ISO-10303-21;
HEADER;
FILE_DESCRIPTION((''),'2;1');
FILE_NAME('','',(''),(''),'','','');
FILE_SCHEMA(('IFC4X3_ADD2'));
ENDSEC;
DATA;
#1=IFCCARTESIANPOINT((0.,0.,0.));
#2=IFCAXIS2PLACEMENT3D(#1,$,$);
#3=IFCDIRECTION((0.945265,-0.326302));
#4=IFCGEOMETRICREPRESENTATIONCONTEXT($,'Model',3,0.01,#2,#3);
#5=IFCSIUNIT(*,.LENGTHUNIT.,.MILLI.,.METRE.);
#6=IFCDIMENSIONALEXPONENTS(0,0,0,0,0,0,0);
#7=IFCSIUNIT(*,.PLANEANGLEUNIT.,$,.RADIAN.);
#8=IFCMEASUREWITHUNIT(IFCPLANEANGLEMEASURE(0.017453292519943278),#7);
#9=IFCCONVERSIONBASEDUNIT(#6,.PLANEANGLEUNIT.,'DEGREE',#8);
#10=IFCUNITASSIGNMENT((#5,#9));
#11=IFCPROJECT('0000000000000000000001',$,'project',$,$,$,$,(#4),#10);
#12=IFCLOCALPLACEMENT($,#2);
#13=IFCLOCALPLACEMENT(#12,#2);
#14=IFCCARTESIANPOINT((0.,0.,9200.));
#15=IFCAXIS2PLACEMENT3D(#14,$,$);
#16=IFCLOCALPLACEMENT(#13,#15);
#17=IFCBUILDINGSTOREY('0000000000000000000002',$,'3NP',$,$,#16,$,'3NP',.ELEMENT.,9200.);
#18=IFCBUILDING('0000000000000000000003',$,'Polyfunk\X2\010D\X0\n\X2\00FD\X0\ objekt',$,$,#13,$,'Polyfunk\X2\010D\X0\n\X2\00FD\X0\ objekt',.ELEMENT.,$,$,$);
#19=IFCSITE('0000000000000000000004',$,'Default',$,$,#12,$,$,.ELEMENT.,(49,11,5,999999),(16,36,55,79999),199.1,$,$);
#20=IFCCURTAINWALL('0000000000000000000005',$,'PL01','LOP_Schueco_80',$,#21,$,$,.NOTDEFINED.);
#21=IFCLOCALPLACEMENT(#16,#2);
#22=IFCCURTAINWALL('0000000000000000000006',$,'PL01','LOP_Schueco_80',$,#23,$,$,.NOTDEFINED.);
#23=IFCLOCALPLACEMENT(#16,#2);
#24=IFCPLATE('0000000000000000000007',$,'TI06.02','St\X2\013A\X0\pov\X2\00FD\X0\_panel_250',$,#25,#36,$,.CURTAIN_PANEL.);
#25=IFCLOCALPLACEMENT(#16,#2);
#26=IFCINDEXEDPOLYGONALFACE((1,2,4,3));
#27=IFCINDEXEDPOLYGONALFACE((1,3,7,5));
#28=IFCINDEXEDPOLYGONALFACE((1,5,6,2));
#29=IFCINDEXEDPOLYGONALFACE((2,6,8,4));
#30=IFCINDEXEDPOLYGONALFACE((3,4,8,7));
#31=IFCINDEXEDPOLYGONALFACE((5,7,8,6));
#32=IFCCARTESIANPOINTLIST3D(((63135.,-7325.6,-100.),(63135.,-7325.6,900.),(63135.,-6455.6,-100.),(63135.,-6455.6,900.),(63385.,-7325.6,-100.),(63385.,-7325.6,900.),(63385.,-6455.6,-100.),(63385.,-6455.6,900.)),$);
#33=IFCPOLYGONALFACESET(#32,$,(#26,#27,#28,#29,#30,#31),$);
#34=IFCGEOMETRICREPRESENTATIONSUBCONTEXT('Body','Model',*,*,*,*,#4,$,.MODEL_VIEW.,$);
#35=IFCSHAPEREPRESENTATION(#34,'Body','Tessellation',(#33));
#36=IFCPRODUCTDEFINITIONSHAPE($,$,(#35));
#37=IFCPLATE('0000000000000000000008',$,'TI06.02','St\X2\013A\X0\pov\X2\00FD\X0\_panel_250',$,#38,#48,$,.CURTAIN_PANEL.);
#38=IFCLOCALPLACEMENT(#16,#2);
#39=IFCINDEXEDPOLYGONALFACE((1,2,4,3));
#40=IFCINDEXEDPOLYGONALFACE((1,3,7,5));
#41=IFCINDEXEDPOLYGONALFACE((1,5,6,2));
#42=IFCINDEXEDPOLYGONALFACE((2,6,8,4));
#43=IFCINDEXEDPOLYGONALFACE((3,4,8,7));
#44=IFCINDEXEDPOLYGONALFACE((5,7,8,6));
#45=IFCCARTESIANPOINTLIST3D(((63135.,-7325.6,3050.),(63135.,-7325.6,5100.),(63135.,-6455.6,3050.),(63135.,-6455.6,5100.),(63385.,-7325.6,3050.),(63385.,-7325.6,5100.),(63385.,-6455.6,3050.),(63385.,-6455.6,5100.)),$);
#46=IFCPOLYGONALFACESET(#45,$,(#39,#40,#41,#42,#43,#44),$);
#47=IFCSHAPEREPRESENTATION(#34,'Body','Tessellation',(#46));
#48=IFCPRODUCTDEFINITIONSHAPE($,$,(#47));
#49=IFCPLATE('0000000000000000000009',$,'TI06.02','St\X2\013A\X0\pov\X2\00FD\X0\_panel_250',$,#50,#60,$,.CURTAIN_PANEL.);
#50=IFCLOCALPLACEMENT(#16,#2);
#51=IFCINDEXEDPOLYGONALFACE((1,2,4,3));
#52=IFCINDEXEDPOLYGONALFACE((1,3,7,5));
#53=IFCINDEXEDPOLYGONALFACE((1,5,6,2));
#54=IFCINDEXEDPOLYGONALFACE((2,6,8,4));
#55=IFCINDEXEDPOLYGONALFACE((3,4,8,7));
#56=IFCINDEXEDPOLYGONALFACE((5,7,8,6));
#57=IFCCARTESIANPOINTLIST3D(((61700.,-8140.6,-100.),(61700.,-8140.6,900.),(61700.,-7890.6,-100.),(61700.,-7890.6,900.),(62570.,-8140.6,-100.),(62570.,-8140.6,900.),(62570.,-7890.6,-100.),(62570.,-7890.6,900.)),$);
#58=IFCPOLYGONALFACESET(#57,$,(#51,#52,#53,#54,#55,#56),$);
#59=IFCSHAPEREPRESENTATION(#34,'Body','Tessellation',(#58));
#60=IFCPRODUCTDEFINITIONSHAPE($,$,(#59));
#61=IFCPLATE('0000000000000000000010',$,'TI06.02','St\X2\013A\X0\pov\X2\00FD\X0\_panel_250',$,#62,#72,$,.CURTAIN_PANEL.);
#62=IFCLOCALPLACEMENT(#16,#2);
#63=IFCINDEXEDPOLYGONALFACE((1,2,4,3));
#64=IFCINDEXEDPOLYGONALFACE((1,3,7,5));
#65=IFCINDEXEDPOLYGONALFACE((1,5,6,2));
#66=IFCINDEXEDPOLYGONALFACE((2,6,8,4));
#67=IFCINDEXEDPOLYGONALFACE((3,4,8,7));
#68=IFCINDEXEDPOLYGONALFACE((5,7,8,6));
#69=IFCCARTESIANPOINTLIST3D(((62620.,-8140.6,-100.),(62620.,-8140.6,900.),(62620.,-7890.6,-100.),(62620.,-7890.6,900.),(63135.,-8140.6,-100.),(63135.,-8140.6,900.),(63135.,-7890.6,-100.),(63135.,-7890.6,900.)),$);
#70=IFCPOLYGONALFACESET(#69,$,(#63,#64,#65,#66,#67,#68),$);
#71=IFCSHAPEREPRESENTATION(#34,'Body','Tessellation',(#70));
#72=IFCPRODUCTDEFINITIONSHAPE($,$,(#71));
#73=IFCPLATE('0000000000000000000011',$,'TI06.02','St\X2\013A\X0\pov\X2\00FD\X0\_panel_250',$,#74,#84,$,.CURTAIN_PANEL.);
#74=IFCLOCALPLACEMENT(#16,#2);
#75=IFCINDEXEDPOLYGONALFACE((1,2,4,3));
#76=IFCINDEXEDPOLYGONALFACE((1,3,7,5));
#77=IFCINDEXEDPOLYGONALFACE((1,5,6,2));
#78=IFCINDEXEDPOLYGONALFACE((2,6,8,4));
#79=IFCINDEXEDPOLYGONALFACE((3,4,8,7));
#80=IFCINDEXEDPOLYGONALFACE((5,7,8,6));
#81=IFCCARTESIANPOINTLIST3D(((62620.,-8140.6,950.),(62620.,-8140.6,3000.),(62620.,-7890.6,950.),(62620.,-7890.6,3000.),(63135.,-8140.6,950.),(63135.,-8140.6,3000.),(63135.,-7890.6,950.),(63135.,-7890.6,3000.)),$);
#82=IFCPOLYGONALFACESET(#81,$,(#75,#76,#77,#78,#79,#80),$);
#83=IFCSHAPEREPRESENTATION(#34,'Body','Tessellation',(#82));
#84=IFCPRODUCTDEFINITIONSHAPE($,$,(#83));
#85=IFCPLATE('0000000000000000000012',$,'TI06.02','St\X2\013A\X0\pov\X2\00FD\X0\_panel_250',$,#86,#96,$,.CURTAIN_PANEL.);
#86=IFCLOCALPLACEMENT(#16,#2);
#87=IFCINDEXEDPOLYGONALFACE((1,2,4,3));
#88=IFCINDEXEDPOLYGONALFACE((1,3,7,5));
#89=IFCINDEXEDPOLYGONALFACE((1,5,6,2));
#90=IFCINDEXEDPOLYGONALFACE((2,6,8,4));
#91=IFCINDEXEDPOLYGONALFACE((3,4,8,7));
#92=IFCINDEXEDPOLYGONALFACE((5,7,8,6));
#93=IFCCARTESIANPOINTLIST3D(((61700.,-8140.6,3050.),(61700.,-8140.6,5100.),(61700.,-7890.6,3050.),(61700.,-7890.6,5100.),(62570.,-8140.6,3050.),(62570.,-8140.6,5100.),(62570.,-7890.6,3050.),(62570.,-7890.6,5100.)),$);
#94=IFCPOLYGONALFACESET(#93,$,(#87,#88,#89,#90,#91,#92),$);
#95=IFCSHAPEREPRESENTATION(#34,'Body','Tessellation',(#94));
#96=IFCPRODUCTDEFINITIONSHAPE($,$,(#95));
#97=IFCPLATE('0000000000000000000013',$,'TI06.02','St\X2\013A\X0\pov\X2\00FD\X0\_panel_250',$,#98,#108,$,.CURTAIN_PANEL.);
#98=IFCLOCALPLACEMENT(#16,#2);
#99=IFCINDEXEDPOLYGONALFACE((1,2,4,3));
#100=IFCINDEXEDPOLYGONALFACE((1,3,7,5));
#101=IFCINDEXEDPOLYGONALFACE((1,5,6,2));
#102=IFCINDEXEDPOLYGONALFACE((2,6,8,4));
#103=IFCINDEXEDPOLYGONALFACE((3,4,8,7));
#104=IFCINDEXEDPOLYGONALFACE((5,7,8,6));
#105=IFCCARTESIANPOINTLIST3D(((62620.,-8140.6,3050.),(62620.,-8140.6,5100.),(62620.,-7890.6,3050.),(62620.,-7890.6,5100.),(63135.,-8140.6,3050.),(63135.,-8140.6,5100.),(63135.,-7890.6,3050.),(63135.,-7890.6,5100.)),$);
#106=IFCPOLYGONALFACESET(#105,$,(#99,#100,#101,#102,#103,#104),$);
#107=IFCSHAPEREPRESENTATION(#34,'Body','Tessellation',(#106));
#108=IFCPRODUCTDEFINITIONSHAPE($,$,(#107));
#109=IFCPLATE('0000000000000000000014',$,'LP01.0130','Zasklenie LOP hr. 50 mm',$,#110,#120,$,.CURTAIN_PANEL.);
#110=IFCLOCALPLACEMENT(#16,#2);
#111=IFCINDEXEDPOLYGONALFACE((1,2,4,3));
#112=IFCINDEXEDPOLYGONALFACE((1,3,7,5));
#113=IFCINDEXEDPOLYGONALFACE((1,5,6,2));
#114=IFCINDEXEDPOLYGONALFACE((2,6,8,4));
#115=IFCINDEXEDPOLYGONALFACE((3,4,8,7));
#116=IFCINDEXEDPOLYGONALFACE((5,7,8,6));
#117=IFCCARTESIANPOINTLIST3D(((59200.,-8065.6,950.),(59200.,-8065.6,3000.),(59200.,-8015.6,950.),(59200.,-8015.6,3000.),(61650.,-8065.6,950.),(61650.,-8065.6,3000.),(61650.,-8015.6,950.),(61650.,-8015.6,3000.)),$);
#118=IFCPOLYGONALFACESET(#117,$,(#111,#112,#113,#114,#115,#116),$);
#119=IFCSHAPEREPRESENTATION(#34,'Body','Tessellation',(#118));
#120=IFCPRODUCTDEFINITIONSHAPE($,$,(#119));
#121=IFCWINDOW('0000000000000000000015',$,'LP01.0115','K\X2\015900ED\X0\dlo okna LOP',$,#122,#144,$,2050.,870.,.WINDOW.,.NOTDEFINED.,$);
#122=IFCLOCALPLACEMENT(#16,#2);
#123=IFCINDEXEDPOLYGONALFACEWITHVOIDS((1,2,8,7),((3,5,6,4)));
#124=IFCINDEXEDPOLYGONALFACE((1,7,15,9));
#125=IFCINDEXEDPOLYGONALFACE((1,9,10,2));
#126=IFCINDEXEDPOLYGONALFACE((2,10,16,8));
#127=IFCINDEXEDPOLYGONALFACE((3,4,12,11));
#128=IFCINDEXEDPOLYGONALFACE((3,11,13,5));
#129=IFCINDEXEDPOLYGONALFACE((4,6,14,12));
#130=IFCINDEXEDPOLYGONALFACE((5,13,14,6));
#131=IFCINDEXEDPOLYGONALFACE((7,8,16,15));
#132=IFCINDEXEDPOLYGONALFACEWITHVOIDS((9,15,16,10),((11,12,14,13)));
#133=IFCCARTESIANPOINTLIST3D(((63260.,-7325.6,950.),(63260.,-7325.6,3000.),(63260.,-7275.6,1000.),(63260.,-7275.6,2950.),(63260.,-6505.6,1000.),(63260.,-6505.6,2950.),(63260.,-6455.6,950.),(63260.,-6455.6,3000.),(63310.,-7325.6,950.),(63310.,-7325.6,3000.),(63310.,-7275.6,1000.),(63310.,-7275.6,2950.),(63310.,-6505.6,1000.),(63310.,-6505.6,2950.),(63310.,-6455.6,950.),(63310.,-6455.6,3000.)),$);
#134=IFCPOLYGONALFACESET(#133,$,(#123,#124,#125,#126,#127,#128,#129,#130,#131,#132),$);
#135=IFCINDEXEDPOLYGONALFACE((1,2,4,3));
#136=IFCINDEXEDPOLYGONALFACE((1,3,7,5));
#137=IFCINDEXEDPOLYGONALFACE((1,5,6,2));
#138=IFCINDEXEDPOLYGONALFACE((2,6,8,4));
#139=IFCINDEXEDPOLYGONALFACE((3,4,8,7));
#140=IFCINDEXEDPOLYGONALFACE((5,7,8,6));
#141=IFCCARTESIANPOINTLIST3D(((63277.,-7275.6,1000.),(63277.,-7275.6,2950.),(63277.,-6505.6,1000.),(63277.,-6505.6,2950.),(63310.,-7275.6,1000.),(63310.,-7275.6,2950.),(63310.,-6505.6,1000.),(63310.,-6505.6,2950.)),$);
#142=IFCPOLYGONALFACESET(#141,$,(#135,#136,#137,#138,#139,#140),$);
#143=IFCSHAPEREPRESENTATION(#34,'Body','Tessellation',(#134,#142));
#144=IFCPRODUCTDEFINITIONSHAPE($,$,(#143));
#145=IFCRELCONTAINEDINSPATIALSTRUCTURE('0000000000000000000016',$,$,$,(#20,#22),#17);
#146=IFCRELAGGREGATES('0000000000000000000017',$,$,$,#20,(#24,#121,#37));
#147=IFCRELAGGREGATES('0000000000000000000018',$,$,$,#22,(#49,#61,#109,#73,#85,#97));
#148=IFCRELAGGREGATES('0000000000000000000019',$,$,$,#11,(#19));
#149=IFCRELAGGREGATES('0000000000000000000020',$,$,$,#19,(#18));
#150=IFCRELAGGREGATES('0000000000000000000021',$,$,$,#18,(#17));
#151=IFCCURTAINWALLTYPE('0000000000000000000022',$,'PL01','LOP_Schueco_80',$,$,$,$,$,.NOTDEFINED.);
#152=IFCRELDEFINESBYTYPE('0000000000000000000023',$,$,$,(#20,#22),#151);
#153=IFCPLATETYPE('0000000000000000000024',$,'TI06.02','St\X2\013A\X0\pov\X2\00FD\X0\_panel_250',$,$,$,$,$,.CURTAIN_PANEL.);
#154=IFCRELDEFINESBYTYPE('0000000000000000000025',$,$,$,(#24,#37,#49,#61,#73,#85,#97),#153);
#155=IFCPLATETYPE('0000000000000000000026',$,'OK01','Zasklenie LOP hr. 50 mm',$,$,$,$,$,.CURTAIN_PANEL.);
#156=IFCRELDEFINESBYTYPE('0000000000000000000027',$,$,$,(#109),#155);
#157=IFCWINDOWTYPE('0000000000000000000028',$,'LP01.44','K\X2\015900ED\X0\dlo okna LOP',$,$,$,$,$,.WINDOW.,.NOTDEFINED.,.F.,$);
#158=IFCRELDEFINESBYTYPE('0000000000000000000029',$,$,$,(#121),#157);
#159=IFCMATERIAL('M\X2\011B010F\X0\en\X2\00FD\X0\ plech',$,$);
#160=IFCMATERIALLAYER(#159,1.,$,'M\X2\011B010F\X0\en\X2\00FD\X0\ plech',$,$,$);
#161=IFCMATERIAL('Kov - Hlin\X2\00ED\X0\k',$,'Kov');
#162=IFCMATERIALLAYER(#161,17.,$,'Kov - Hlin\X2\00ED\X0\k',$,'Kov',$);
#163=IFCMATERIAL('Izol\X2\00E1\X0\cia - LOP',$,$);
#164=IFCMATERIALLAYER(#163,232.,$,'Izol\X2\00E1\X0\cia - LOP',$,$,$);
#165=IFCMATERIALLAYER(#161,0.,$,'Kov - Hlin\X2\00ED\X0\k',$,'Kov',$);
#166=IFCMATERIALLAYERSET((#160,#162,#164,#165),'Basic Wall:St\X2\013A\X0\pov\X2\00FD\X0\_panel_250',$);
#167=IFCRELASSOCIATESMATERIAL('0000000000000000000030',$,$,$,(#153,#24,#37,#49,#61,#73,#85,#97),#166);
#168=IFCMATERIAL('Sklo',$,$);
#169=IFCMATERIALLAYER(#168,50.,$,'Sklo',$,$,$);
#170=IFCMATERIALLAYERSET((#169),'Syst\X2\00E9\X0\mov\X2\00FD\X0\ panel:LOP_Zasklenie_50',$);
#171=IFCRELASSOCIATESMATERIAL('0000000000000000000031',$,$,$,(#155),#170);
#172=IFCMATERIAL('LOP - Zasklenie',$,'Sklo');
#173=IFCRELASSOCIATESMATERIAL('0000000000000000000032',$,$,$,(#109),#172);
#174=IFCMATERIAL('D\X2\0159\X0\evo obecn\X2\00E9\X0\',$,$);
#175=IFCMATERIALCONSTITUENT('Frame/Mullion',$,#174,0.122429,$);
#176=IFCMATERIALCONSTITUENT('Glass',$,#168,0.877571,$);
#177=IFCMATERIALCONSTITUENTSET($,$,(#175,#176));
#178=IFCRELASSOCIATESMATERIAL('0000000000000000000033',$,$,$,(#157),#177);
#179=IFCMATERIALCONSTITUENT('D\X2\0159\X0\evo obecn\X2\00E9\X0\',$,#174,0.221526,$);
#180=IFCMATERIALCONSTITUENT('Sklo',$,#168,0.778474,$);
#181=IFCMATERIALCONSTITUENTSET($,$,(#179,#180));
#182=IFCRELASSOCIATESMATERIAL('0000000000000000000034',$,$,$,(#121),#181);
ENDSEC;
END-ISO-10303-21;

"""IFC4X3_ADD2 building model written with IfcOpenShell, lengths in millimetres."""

from ifc_helpers import new_model, entity, si_unit, converted_unit, direction, frame, frame_2d, origin, origin_2d_with_axis, place, context, subcontext, project, spatial, polyline, rectangle, outline, extrude, source, transform, mapped, material, layer, layer_set, layer_usage, constituent, constituent_set, type_object, type_shapes, element, aggregate, save


model = new_model("IFC4X3_ADD2")

# Units and contexts
model_context = context("Model", 3, precision=0.01, world=origin(), true_north=direction((0.945265, -0.326302)))
body_context = subcontext(model_context, "Body", "Model", "MODEL_VIEW")
ifc_project = project(units=[si_unit("LENGTHUNIT", "METRE", prefix="MILLI"), converted_unit("PLANEANGLEUNIT", "DEGREE", entity("IfcPlaneAngleMeasure", 0.017453292519943278), si_unit("PLANEANGLEUNIT", "RADIAN"), dimensions=[0, 0, 0, 0, 0, 0, 0])], contexts=[model_context])

# Site, building, storey
site_placement = place(None, origin())
site = spatial("IfcSite", under=ifc_project, at=site_placement, Name="Default", CompositionType="ELEMENT", RefLatitude=(49, 11, 5, 999999), RefLongitude=(16, 36, 55, 79999), RefElevation=199.1)
building_placement = place(site_placement, origin())
building = spatial("IfcBuilding", under=site, at=building_placement, Name="Polyfunkčný objekt", LongName="Polyfunkčný objekt", CompositionType="ELEMENT")
storey_placement = place(building_placement, frame((0.0, 0.0, 9200.0)))
storey = spatial("IfcBuildingStorey", under=building, at=storey_placement, Name="3NP", LongName="3NP", CompositionType="ELEMENT", Elevation=9200.0)

# Curtain walls
curtain_wall_type = type_object("IfcCurtainWallType", Name="PL01", Description="LOP_Schueco_80", PredefinedType="NOTDEFINED")
curtain_wall_1_placement = place(storey_placement, frame((0.0, 0.0, -9200.0)))
curtain_wall_1 = element("IfcCurtainWall", 1, at=curtain_wall_1_placement, inside=storey, type_object=curtain_wall_type, Name="PL01", Description="LOP_Schueco_80", PredefinedType="NOTDEFINED")
curtain_wall_2_placement = place(storey_placement, frame((0.0, 0.0, -9200.0)))
curtain_wall_2 = element("IfcCurtainWall", 2, at=curtain_wall_2_placement, inside=storey, type_object=curtain_wall_type, Name="PL01", Description="LOP_Schueco_80", PredefinedType="NOTDEFINED")

# Plates
ifc_material_1 = material(Name="Měďený plech")
ifc_layer_1 = layer(ifc_material_1, 1.0, Name="Měďený plech")
ifc_material_2 = material(Name="Kov - Hliník", Category="Kov")
ifc_layer_2 = layer(ifc_material_2, 17.0, Name="Kov - Hliník", Category="Kov")
ifc_material_3 = material(Name="Izolácia - LOP")
ifc_layer_3 = layer(ifc_material_3, 232.0, Name="Izolácia - LOP")
ifc_layer_4 = layer(ifc_material_2, 0.0, Name="Kov - Hliník", Category="Kov")
ifc_layer_set_1 = layer_set([ifc_layer_1, ifc_layer_2, ifc_layer_3, ifc_layer_4], Name="Basic Wall:Stĺpový_panel_250")
ifc_layer_usage_1 = layer_usage(ifc_layer_set_1, "AXIS2", "NEGATIVE", 125.0)
plate_type_1 = type_object("IfcPlateType", Name="TI06.02", Description="Stĺpový_panel_250", PredefinedType="CURTAIN_PANEL", material=ifc_layer_set_1)
plate_1_placement = place(storey_placement, frame((63260.0, -6455.6, -100.0), z_axis=(0.0, 0.0, 1.0), x_axis=(0.0, -1.0, 0.0)))
plate_1 = element("IfcPlate", 3, at=plate_1_placement, type_object=plate_type_1, material=ifc_layer_usage_1, Name="TI06.02", Description="Stĺpový_panel_250", PredefinedType="CURTAIN_PANEL", context=body_context, shape_type="SweptSolid", body=[
    extrude(rectangle(XDim=250.0, YDim=870.0, at=frame_2d((0.0, 0.0), x_axis=(1.0, 0.0))), frame((435.0, 0.0, 0.0), z_axis=(0.0, 0.0, 1.0), x_axis=(0.0, 1.0, 0.0)), (0.0, 0.0, 1.0), 1000.0),
])
ifc_layer_usage_2 = layer_usage(ifc_layer_set_1, "AXIS2", "NEGATIVE", 125.0)
plate_2_placement = place(storey_placement, frame((63260.0, -6455.6, 3050.0), z_axis=(0.0, 0.0, 1.0), x_axis=(0.0, -1.0, 0.0)))
plate_2 = element("IfcPlate", 4, at=plate_2_placement, type_object=plate_type_1, material=ifc_layer_usage_2, Name="TI06.02", Description="Stĺpový_panel_250", PredefinedType="CURTAIN_PANEL", context=body_context, shape_type="SweptSolid", body=[
    extrude(rectangle(XDim=250.0, YDim=870.0, at=frame_2d((0.0, 0.0), x_axis=(1.0, 0.0))), frame((435.0, 0.0, 0.0), z_axis=(0.0, 0.0, 1.0), x_axis=(0.0, 1.0, 0.0)), (0.0, 0.0, 1.0), 2050.0),
])
ifc_layer_usage_3 = layer_usage(ifc_layer_set_1, "AXIS2", "POSITIVE", -125.0)
plate_3_placement = place(storey_placement, frame((61700.0, -8015.6, -100.0)))
plate_3 = element("IfcPlate", 5, at=plate_3_placement, type_object=plate_type_1, material=ifc_layer_usage_3, Name="TI06.02", Description="Stĺpový_panel_250", PredefinedType="CURTAIN_PANEL", context=body_context, shape_type="SweptSolid", body=[
    extrude(rectangle(XDim=250.0, YDim=870.0, at=frame_2d((0.0, 0.0), x_axis=(1.0, 0.0))), frame((435.0, 0.0, 0.0), z_axis=(0.0, 0.0, 1.0), x_axis=(0.0, 1.0, 0.0)), (0.0, 0.0, 1.0), 1000.0),
])
ifc_layer_usage_4 = layer_usage(ifc_layer_set_1, "AXIS2", "POSITIVE", -125.0)
plate_4_placement = place(storey_placement, frame((62620.0, -8015.6, -100.0)))
plate_4 = element("IfcPlate", 6, at=plate_4_placement, type_object=plate_type_1, material=ifc_layer_usage_4, Name="TI06.02", Description="Stĺpový_panel_250", PredefinedType="CURTAIN_PANEL", context=body_context, shape_type="SweptSolid", body=[
    extrude(rectangle(XDim=250.0, YDim=515.0, at=frame_2d((0.0, 0.0), x_axis=(1.0, 0.0))), frame((257.5, 0.0, 0.0), z_axis=(0.0, 0.0, 1.0), x_axis=(0.0, 1.0, 0.0)), (0.0, 0.0, 1.0), 1000.0),
])
ifc_layer_usage_5 = layer_usage(ifc_layer_set_1, "AXIS2", "POSITIVE", -125.0)
plate_5_placement = place(storey_placement, frame((62620.0, -8015.6, 950.0)))
plate_5 = element("IfcPlate", 7, at=plate_5_placement, type_object=plate_type_1, material=ifc_layer_usage_5, Name="TI06.02", Description="Stĺpový_panel_250", PredefinedType="CURTAIN_PANEL", context=body_context, shape_type="SweptSolid", body=[
    extrude(rectangle(XDim=250.0, YDim=515.0, at=frame_2d((0.0, 0.0), x_axis=(1.0, 0.0))), frame((257.5, 0.0, 0.0), z_axis=(0.0, 0.0, 1.0), x_axis=(0.0, 1.0, 0.0)), (0.0, 0.0, 1.0), 2050.0),
])
ifc_layer_usage_6 = layer_usage(ifc_layer_set_1, "AXIS2", "POSITIVE", -125.0)
plate_6_placement = place(storey_placement, frame((61700.0, -8015.6, 3050.0)))
plate_6 = element("IfcPlate", 8, at=plate_6_placement, type_object=plate_type_1, material=ifc_layer_usage_6, Name="TI06.02", Description="Stĺpový_panel_250", PredefinedType="CURTAIN_PANEL", context=body_context, shape_type="SweptSolid", body=[
    extrude(rectangle(XDim=250.0, YDim=870.0, at=frame_2d((0.0, 0.0), x_axis=(1.0, 0.0))), frame((435.0, 0.0, 0.0), z_axis=(0.0, 0.0, 1.0), x_axis=(0.0, 1.0, 0.0)), (0.0, 0.0, 1.0), 2050.0),
])
ifc_layer_usage_7 = layer_usage(ifc_layer_set_1, "AXIS2", "POSITIVE", -125.0)
plate_7_placement = place(storey_placement, frame((62620.0, -8015.6, 3050.0)))
plate_7 = element("IfcPlate", 9, at=plate_7_placement, type_object=plate_type_1, material=ifc_layer_usage_7, Name="TI06.02", Description="Stĺpový_panel_250", PredefinedType="CURTAIN_PANEL", context=body_context, shape_type="SweptSolid", body=[
    extrude(rectangle(XDim=250.0, YDim=515.0, at=frame_2d((0.0, 0.0), x_axis=(1.0, 0.0))), frame((257.5, 0.0, 0.0), z_axis=(0.0, 0.0, 1.0), x_axis=(0.0, 1.0, 0.0)), (0.0, 0.0, 1.0), 2050.0),
])
ifc_material_4 = material(Name="LOP - Zasklenie", Category="Sklo")
ifc_material_5 = material(Name="Sklo")
ifc_layer_5 = layer(ifc_material_5, 50.0, Name="Sklo")
ifc_layer_set_2 = layer_set([ifc_layer_5], Name="Systémový panel:LOP_Zasklenie_50")
plate_type_2 = type_object("IfcPlateType", Name="OK01", Description="Zasklenie LOP hr. 50 mm", PredefinedType="CURTAIN_PANEL", material=ifc_layer_set_2)
shared_shape_1 = source(origin(), body_context, "Body", "SweptSolid", [
    extrude(rectangle(XDim=50.0, YDim=2450.0, at=origin_2d_with_axis()), frame((0.0, -25.0, 0.0), z_axis=(0.0, 0.0, 1.0), x_axis=(0.0, 1.0, 0.0)), (0.0, 0.0, 1.0), 2050.0),
])
type_shapes(plate_type_2, [shared_shape_1])
plate_8_placement = place(curtain_wall_2_placement, frame((60425.0, -8015.6, 10150.0)))
plate_8 = element("IfcPlate", 10, at=plate_8_placement, type_object=plate_type_2, material=ifc_material_4, Name="LP01.0130", Description="Zasklenie LOP hr. 50 mm", PredefinedType="CURTAIN_PANEL", context=body_context, shape_type="MappedRepresentation", body=[
    mapped(shared_shape_1, transform((0.0, 0.0, 0.0), scale=1.0)),
])

# Window
ifc_material_6 = material(Name="Dřevo obecné")
ifc_constituent_1 = constituent(ifc_material_6, Name="Dřevo obecné", fraction=0.221526)
ifc_constituent_2 = constituent(ifc_material_5, Name="Sklo", fraction=0.778474)
ifc_constituent_set_1 = constituent_set(constituents=[ifc_constituent_1, ifc_constituent_2])
ifc_constituent_3 = constituent(ifc_material_6, Name="Frame/Mullion", fraction=0.122429)
ifc_constituent_4 = constituent(ifc_material_5, Name="Glass", fraction=0.877571)
ifc_constituent_set_2 = constituent_set(constituents=[ifc_constituent_3, ifc_constituent_4])
window_type_1 = type_object("IfcWindowType", Name="LP01.44", Description="Křídlo okna LOP", ParameterTakesPrecedence=False, PartitioningType="NOTDEFINED", PredefinedType="WINDOW", material=ifc_constituent_set_2)
shared_shape_2 = source(origin(), body_context, "Body", "SweptSolid", [
    extrude(outline(polyline([(-1025.0, -435.0), (1025.0, -435.0), (1025.0, 435.0), (-1025.0, 435.0), (-1025.0, -435.0)]), holes=[polyline([(-975.0, -385.0), (-975.0, 385.0), (975.0, 385.0), (975.0, -385.0), (-975.0, -385.0)])]), frame((0.0, 0.0, 1025.0), z_axis=(0.0, 1.0, 0.0), x_axis=(0.0, 0.0, -1.0)), (0.0, 0.0, 1.0), 50.0),
    extrude(rectangle(XDim=33.0, YDim=770.0, at=origin_2d_with_axis()), frame((0.0, 33.5, 50.0), z_axis=(0.0, 0.0, 1.0), x_axis=(0.0, -1.0, 0.0)), (0.0, 0.0, 1.0), 1950.0),
])
type_shapes(window_type_1, [shared_shape_2])
window_1_placement = place(curtain_wall_1_placement, frame((63260.0, -6890.6, 10150.0), z_axis=(0.0, 0.0, 1.0), x_axis=(0.0, -1.0, 0.0)))
window_1 = element("IfcWindow", 11, at=window_1_placement, type_object=window_type_1, material=ifc_constituent_set_1, Name="LP01.0115", Description="Křídlo okna LOP", OverallHeight=2050.0, OverallWidth=870.0, PartitioningType="NOTDEFINED", PredefinedType="WINDOW", context=body_context, shape_type="MappedRepresentation", body=[
    mapped(shared_shape_2, transform((0.0, 0.0, 0.0), scale=1.0)),
])
aggregate(curtain_wall_1, [plate_1, window_1, plate_2])
aggregate(curtain_wall_2, [plate_3, plate_4, plate_8, plate_5, plate_6, plate_7])

save(model, "model.ifc")
